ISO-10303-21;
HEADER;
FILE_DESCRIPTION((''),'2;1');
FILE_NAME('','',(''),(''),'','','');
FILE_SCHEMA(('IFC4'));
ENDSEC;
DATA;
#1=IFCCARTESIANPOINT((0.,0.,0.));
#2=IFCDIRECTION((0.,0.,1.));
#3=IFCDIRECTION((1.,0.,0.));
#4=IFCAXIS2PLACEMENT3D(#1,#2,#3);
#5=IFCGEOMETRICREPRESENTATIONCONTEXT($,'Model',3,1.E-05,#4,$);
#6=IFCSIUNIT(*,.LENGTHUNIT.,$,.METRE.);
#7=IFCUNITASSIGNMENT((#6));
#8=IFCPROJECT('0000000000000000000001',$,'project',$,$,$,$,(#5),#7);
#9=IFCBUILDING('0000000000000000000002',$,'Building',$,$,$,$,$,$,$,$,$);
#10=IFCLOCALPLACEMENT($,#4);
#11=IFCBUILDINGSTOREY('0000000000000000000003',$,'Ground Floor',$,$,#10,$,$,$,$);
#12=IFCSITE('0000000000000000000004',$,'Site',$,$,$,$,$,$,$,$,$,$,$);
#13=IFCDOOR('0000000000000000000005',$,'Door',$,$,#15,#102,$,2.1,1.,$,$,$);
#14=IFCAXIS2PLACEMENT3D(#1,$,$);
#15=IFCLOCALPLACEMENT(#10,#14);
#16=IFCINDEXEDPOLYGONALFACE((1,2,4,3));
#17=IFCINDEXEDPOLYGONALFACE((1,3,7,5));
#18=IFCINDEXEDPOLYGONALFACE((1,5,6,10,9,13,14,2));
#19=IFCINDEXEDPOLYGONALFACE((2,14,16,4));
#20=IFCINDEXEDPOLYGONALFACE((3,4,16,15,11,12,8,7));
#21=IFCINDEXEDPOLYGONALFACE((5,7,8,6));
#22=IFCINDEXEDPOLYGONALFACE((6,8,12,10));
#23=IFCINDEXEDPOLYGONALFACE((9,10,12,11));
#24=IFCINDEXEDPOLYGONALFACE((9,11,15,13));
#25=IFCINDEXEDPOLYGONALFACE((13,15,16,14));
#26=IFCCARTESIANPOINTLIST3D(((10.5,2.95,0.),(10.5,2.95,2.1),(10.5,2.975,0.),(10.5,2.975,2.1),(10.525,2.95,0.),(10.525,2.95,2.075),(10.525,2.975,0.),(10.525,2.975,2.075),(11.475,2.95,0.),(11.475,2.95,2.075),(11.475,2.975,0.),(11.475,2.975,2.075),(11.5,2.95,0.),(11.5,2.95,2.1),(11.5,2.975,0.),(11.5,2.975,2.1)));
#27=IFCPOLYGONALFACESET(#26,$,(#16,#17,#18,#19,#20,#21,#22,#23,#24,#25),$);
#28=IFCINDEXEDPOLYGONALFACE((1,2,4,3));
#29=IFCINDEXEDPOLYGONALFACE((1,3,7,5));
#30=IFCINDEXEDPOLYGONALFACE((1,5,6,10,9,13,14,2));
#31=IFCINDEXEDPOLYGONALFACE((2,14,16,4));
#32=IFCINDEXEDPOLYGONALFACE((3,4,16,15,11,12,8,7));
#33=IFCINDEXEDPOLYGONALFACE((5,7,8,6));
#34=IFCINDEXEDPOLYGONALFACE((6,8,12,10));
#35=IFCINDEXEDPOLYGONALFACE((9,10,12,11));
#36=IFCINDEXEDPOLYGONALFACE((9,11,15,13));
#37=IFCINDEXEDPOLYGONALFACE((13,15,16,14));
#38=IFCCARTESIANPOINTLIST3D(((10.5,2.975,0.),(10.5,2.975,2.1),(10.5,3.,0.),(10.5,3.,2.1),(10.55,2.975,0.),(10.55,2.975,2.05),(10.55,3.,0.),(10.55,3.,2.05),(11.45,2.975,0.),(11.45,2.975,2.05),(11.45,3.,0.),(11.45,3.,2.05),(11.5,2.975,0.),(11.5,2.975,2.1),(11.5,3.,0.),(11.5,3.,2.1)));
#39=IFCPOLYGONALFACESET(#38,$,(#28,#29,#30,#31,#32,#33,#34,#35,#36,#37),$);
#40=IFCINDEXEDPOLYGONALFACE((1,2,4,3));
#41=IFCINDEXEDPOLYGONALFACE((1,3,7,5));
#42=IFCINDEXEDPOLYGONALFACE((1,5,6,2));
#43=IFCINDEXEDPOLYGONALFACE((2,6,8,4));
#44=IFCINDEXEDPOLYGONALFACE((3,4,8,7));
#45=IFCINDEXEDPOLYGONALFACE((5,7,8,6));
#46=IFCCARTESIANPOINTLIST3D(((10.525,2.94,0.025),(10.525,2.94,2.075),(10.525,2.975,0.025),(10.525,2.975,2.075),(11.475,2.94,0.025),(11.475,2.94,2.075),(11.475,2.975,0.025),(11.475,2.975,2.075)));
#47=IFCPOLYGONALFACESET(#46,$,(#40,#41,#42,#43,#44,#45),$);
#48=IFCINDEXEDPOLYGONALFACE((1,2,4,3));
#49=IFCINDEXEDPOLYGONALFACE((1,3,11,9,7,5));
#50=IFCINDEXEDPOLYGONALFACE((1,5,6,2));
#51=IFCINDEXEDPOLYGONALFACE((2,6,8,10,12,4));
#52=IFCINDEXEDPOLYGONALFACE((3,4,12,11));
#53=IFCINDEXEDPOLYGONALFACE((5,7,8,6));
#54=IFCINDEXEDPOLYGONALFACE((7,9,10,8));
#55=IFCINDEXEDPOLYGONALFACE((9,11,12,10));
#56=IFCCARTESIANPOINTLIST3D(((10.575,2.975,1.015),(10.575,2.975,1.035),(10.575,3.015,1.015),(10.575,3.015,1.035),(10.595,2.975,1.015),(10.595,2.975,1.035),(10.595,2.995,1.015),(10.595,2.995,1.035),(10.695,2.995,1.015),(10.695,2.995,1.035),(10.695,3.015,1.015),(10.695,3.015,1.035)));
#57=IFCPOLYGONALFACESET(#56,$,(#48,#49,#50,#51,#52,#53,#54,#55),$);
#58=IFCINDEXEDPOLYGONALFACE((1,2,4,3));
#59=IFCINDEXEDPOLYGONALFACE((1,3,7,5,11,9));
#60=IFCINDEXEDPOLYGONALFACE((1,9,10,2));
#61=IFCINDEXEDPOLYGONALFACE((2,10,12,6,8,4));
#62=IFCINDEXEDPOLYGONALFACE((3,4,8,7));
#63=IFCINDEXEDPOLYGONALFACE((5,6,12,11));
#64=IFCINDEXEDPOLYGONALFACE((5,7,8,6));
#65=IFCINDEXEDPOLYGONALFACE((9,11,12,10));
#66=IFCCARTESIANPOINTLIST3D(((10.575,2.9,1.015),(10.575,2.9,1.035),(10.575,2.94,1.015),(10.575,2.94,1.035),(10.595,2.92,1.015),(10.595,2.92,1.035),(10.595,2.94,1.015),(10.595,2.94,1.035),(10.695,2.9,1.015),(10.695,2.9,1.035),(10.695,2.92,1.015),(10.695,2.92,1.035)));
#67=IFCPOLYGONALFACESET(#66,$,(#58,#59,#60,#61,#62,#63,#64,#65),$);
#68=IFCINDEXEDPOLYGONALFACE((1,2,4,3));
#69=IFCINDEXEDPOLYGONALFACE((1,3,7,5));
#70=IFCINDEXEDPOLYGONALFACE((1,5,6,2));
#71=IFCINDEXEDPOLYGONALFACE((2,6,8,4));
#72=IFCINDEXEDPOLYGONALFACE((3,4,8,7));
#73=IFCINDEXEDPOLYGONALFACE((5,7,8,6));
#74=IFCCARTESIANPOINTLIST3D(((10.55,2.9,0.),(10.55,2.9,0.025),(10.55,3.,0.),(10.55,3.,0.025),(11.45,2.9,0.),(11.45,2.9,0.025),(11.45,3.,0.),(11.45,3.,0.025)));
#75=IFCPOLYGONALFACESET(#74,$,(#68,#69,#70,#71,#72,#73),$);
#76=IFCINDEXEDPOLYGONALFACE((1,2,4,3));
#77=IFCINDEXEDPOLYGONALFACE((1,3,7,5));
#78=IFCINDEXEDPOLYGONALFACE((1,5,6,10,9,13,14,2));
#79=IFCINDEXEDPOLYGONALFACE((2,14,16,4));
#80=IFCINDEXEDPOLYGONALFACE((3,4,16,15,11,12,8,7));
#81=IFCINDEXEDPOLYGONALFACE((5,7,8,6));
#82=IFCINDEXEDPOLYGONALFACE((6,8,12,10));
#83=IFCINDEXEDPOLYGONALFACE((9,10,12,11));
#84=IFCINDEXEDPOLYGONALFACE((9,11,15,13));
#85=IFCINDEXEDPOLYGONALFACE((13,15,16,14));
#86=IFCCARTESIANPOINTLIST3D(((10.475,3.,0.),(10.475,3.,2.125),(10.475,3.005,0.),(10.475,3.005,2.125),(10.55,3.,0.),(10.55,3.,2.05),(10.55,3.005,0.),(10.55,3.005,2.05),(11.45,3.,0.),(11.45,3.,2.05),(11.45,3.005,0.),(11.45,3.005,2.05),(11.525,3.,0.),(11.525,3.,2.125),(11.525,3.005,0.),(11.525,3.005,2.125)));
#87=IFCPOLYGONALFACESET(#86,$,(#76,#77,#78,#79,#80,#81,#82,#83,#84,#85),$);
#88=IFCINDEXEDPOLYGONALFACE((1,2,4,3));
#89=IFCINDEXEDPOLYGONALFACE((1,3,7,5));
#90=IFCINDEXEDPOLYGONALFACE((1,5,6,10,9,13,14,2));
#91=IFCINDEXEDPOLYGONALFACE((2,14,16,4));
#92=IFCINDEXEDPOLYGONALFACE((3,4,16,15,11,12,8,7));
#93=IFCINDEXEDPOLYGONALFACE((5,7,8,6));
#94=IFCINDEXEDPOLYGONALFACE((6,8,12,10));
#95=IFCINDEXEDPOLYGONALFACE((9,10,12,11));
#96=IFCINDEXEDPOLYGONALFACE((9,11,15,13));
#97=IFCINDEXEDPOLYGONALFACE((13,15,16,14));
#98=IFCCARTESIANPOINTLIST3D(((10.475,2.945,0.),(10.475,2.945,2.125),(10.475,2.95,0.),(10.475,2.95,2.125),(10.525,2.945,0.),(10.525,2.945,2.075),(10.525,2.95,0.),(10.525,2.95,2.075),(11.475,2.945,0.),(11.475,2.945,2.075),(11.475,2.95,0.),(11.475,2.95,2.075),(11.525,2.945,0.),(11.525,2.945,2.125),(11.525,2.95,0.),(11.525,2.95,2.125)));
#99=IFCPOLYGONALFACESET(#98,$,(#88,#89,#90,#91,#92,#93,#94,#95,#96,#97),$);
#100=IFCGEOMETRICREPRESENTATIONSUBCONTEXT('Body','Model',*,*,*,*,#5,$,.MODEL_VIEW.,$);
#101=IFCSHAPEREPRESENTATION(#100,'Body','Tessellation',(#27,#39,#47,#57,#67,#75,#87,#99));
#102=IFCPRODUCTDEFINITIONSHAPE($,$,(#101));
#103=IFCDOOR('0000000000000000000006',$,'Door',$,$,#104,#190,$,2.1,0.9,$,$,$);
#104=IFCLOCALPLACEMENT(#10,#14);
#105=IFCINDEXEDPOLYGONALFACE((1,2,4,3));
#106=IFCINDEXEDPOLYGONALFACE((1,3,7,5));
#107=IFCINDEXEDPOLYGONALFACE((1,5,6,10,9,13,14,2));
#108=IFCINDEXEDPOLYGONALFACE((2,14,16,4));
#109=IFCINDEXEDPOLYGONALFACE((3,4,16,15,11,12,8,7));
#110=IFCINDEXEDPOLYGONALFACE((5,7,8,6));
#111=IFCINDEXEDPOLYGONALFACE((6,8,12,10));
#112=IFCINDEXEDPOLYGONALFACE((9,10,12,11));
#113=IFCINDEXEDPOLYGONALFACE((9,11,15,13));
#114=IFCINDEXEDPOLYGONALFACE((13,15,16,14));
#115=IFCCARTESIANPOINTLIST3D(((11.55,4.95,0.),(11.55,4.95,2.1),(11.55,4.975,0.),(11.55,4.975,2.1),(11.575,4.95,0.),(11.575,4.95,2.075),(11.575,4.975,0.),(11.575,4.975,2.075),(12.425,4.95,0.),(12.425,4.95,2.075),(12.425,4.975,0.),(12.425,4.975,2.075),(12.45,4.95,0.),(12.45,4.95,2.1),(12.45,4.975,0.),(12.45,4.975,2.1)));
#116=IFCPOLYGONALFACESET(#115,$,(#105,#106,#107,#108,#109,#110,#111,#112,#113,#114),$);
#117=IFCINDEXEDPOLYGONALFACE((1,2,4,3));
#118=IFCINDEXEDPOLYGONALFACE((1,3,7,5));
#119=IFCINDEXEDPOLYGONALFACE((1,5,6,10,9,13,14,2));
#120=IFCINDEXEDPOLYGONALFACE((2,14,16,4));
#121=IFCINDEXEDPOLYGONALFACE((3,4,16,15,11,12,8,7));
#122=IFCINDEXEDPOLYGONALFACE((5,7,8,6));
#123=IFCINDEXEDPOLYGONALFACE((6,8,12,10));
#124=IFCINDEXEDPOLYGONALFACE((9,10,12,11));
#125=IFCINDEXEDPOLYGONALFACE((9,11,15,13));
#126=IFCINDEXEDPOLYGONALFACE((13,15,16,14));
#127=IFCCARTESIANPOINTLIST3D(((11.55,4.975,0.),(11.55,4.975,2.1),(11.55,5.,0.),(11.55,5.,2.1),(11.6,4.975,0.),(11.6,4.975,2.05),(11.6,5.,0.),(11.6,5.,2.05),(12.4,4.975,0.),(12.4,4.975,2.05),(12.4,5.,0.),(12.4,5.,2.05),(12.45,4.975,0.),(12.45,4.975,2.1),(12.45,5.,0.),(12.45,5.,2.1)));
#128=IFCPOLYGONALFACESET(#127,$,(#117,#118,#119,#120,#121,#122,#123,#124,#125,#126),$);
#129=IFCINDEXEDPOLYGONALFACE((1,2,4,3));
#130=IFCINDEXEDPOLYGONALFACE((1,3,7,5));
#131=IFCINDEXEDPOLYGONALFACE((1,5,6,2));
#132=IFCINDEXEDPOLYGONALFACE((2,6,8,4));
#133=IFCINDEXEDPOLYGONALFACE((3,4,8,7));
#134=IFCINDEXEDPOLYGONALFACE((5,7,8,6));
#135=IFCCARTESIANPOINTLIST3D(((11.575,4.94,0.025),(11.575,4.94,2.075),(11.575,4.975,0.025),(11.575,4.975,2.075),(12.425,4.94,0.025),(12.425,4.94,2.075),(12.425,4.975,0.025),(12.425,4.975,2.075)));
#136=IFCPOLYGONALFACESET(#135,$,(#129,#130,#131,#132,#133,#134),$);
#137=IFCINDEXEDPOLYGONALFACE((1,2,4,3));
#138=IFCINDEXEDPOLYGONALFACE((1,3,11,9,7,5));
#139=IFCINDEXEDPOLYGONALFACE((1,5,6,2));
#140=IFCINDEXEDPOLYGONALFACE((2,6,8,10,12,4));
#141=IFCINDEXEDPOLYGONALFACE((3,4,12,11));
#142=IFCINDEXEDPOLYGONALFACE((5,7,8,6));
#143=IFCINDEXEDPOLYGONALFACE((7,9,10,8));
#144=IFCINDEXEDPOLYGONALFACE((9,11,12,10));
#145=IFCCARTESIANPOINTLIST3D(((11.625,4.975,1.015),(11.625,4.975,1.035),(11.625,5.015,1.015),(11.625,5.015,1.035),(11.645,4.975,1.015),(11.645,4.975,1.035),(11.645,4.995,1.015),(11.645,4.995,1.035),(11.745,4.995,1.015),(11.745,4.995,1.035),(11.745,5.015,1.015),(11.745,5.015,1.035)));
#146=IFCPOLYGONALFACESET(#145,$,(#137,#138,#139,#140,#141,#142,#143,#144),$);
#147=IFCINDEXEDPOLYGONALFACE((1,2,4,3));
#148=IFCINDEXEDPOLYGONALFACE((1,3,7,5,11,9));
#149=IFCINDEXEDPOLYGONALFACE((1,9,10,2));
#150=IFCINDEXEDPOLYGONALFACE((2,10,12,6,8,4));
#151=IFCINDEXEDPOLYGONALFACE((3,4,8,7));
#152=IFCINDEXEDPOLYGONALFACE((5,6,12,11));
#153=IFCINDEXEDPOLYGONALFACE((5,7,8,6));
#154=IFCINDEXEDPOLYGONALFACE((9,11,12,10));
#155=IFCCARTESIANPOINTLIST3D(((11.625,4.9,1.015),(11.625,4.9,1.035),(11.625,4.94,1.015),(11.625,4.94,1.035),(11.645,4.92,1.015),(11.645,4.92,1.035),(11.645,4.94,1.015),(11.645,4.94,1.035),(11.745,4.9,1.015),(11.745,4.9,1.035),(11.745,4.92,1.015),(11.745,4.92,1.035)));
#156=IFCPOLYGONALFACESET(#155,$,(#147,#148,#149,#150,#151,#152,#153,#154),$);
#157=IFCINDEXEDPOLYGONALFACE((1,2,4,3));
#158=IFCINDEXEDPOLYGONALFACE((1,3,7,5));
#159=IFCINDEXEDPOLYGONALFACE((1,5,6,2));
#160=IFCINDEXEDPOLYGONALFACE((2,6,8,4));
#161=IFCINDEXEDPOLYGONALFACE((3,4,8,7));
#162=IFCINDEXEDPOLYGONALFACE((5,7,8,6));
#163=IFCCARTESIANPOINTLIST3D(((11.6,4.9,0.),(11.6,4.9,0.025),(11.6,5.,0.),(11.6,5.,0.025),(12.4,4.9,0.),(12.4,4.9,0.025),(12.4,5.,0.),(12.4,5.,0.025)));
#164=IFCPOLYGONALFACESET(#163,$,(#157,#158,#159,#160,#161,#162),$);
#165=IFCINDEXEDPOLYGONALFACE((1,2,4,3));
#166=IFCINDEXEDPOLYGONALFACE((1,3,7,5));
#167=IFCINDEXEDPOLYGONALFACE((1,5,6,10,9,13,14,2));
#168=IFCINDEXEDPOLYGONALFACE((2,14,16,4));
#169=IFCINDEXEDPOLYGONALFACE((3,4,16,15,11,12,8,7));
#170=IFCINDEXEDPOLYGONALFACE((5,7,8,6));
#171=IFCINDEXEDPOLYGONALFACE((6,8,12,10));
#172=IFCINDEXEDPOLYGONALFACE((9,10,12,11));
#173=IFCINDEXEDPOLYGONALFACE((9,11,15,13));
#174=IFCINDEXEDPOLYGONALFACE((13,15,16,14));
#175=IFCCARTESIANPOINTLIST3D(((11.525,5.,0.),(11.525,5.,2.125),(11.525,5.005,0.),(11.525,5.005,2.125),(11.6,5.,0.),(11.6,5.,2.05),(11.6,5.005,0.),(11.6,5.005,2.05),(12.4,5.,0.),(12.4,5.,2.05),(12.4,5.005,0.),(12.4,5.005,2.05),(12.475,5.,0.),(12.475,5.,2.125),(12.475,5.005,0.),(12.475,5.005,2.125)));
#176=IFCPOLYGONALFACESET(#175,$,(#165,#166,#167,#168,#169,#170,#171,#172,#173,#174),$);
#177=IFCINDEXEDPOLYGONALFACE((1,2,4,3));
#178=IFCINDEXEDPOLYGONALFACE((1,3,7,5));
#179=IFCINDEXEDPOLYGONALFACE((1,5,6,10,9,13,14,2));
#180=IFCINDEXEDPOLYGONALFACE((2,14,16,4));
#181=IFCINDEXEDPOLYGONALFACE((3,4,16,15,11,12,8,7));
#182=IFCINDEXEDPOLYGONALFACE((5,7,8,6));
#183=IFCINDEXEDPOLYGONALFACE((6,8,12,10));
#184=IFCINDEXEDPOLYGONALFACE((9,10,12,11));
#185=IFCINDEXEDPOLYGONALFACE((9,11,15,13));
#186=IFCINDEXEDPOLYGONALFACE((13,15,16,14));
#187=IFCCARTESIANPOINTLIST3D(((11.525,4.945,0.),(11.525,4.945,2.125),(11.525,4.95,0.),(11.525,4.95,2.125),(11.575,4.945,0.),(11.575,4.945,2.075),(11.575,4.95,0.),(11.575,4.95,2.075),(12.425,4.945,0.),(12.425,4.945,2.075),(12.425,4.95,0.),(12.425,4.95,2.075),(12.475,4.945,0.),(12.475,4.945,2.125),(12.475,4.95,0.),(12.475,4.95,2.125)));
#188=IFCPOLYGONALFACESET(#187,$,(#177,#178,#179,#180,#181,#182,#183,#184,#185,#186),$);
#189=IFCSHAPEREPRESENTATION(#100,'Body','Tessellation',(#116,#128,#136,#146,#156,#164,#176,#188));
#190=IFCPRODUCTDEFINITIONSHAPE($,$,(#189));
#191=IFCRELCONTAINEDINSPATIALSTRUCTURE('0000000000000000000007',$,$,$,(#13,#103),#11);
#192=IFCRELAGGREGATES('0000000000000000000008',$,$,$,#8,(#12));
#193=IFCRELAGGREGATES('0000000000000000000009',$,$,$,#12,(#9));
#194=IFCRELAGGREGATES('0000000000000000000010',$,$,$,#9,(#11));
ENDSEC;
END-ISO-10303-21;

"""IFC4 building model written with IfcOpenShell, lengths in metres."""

from ifc_helpers import new_model, si_unit, frame, origin_with_axes, place, context, subcontext, project, spatial, line, indexed_curve, outline, extrude, element, save


model = new_model("IFC4")

# Units and contexts
model_context = context("Model", 3, precision=1e-05, world=origin_with_axes())
body_context = subcontext(model_context, "Body", "Model", "MODEL_VIEW")
ifc_project = project(units=[si_unit("LENGTHUNIT", "METRE")], contexts=[model_context])

# Site, building, storey
site = spatial("IfcSite", under=ifc_project, Name="Site")
building = spatial("IfcBuilding", under=site, Name="Building")
storey_placement = place(None, origin_with_axes())
storey = spatial("IfcBuildingStorey", under=building, at=storey_placement, Name="Ground Floor")

# Doors
door_1_placement = place(storey_placement, frame((11.5, 3.0, 0.0), z_axis=(0.0, 0.0, 1.0), x_axis=(-1.0, 0.0, 0.0)))
element("IfcDoor", 1, at=door_1_placement, inside=storey, Name="Door", OverallHeight=2.1, OverallWidth=1.0, context=body_context, shape_type="SweptSolid", body=[
    extrude(outline(indexed_curve([(0.0, 0.0), (0.0, 2.1), (1.0, 2.1), (1.0, 0.0), (0.975, 0.0), (0.975, 2.075), (0.025, 2.075), (0.025, 0.0)], segments=[line(1, 2, 3, 4, 5, 6, 7, 8, 1)])), frame((0.0, 0.025, 0.0), z_axis=(0.0, -1.0, 0.0), x_axis=(1.0, 0.0, 0.0)), (0.0, 0.0, -1.0), 0.025),
    extrude(outline(indexed_curve([(0.0, 0.0), (0.0, 2.1), (1.0, 2.1), (1.0, 0.0), (0.95, 0.0), (0.95, 2.05), (0.05, 2.05), (0.05, 0.0)], segments=[line(1, 2, 3, 4, 5, 6, 7, 8, 1)])), frame((0.0, 0.0, 0.0), z_axis=(0.0, -1.0, 0.0), x_axis=(1.0, 0.0, 0.0)), (0.0, 0.0, -1.0), 0.025),
    extrude(outline(indexed_curve([(0.0, 0.0), (0.95, 0.0), (0.95, 0.035), (0.0, 0.035)], segments=[line(1, 2, 3, 4, 1)])), frame((0.025, 0.025, 0.025), z_axis=(0.0, 0.0, 1.0), x_axis=(1.0, 0.0, 0.0)), (0.0, 0.0, 1.0), 2.05),
    extrude(outline(indexed_curve([(0.0, 0.0), (0.0, -0.04), (-0.12, -0.04), (-0.12, -0.02), (-0.02, -0.02), (-0.02, 0.0)], segments=[line(1, 2, 3, 4, 5, 6, 1)])), frame((0.925, 0.025, 1.015), z_axis=(0.0, 0.0, 1.0), x_axis=(1.0, 0.0, 0.0)), (0.0, 0.0, 1.0), 0.02),
    extrude(outline(indexed_curve([(0.0, 0.0), (0.0, 0.04), (-0.12, 0.04), (-0.12, 0.02), (-0.02, 0.02), (-0.02, 0.0)], segments=[line(1, 2, 3, 4, 5, 6, 1)])), frame((0.925, 0.06, 1.015), z_axis=(0.0, 0.0, 1.0), x_axis=(1.0, 0.0, 0.0)), (0.0, 0.0, 1.0), 0.02),
    extrude(outline(indexed_curve([(0.0, 0.0), (0.9, 0.0), (0.9, 0.1), (0.0, 0.1)], segments=[line(1, 2, 3, 4, 1)])), frame((0.05, 0.0, 0.0), z_axis=(0.0, 0.0, 1.0), x_axis=(1.0, 0.0, 0.0)), (0.0, 0.0, 1.0), 0.025),
    extrude(outline(indexed_curve([(0.0, 0.0), (0.0, 2.125), (1.05, 2.125), (1.05, 0.0), (0.975, 0.0), (0.975, 2.05), (0.075, 2.05), (0.075, 0.0)], segments=[line(1, 2, 3, 4, 5, 6, 7, 8, 1)])), frame((-0.025, -0.005, 0.0), z_axis=(0.0, -1.0, 0.0), x_axis=(1.0, 0.0, 0.0)), (0.0, 0.0, -1.0), 0.005),
    extrude(outline(indexed_curve([(0.0, 0.0), (0.0, 2.125), (1.05, 2.125), (1.05, 0.0), (1.0, 0.0), (1.0, 2.075), (0.05, 2.075), (0.05, 0.0)], segments=[line(1, 2, 3, 4, 5, 6, 7, 8, 1)])), frame((-0.025, 0.05, 0.0), z_axis=(0.0, -1.0, 0.0), x_axis=(1.0, 0.0, 0.0)), (0.0, 0.0, -1.0), 0.005),
])
door_2_placement = place(storey_placement, frame((12.45, 5.0, 0.0), z_axis=(0.0, 0.0, 1.0), x_axis=(-1.0, 0.0, 0.0)))
element("IfcDoor", 2, at=door_2_placement, inside=storey, Name="Door", OverallHeight=2.1, OverallWidth=0.9, context=body_context, shape_type="SweptSolid", body=[
    extrude(outline(indexed_curve([(0.0, 0.0), (0.0, 2.1), (0.9, 2.1), (0.9, 0.0), (0.875, 0.0), (0.875, 2.075), (0.025, 2.075), (0.025, 0.0)], segments=[line(1, 2, 3, 4, 5, 6, 7, 8, 1)])), frame((0.0, 0.025, 0.0), z_axis=(0.0, -1.0, 0.0), x_axis=(1.0, 0.0, 0.0)), (0.0, 0.0, -1.0), 0.025),
    extrude(outline(indexed_curve([(0.0, 0.0), (0.0, 2.1), (0.9, 2.1), (0.9, 0.0), (0.85, 0.0), (0.85, 2.05), (0.05, 2.05), (0.05, 0.0)], segments=[line(1, 2, 3, 4, 5, 6, 7, 8, 1)])), frame((0.0, 0.0, 0.0), z_axis=(0.0, -1.0, 0.0), x_axis=(1.0, 0.0, 0.0)), (0.0, 0.0, -1.0), 0.025),
    extrude(outline(indexed_curve([(0.0, 0.0), (0.85, 0.0), (0.85, 0.035), (0.0, 0.035)], segments=[line(1, 2, 3, 4, 1)])), frame((0.025, 0.025, 0.025), z_axis=(0.0, 0.0, 1.0), x_axis=(1.0, 0.0, 0.0)), (0.0, 0.0, 1.0), 2.05),
    extrude(outline(indexed_curve([(0.0, 0.0), (0.0, -0.04), (-0.12, -0.04), (-0.12, -0.02), (-0.02, -0.02), (-0.02, 0.0)], segments=[line(1, 2, 3, 4, 5, 6, 1)])), frame((0.825, 0.025, 1.015), z_axis=(0.0, 0.0, 1.0), x_axis=(1.0, 0.0, 0.0)), (0.0, 0.0, 1.0), 0.02),
    extrude(outline(indexed_curve([(0.0, 0.0), (0.0, 0.04), (-0.12, 0.04), (-0.12, 0.02), (-0.02, 0.02), (-0.02, 0.0)], segments=[line(1, 2, 3, 4, 5, 6, 1)])), frame((0.825, 0.06, 1.015), z_axis=(0.0, 0.0, 1.0), x_axis=(1.0, 0.0, 0.0)), (0.0, 0.0, 1.0), 0.02),
    extrude(outline(indexed_curve([(0.0, 0.0), (0.8, 0.0), (0.8, 0.1), (0.0, 0.1)], segments=[line(1, 2, 3, 4, 1)])), frame((0.05, 0.0, 0.0), z_axis=(0.0, 0.0, 1.0), x_axis=(1.0, 0.0, 0.0)), (0.0, 0.0, 1.0), 0.025),
    extrude(outline(indexed_curve([(0.0, 0.0), (0.0, 2.125), (0.95, 2.125), (0.95, 0.0), (0.875, 0.0), (0.875, 2.05), (0.075, 2.05), (0.075, 0.0)], segments=[line(1, 2, 3, 4, 5, 6, 7, 8, 1)])), frame((-0.025, -0.005, 0.0), z_axis=(0.0, -1.0, 0.0), x_axis=(1.0, 0.0, 0.0)), (0.0, 0.0, -1.0), 0.005),
    extrude(outline(indexed_curve([(0.0, 0.0), (0.0, 2.125), (0.95, 2.125), (0.95, 0.0), (0.9, 0.0), (0.9, 2.075), (0.05, 2.075), (0.05, 0.0)], segments=[line(1, 2, 3, 4, 5, 6, 7, 8, 1)])), frame((-0.025, 0.05, 0.0), z_axis=(0.0, -1.0, 0.0), x_axis=(1.0, 0.0, 0.0)), (0.0, 0.0, -1.0), 0.005),
])

save(model, "model.ifc")
